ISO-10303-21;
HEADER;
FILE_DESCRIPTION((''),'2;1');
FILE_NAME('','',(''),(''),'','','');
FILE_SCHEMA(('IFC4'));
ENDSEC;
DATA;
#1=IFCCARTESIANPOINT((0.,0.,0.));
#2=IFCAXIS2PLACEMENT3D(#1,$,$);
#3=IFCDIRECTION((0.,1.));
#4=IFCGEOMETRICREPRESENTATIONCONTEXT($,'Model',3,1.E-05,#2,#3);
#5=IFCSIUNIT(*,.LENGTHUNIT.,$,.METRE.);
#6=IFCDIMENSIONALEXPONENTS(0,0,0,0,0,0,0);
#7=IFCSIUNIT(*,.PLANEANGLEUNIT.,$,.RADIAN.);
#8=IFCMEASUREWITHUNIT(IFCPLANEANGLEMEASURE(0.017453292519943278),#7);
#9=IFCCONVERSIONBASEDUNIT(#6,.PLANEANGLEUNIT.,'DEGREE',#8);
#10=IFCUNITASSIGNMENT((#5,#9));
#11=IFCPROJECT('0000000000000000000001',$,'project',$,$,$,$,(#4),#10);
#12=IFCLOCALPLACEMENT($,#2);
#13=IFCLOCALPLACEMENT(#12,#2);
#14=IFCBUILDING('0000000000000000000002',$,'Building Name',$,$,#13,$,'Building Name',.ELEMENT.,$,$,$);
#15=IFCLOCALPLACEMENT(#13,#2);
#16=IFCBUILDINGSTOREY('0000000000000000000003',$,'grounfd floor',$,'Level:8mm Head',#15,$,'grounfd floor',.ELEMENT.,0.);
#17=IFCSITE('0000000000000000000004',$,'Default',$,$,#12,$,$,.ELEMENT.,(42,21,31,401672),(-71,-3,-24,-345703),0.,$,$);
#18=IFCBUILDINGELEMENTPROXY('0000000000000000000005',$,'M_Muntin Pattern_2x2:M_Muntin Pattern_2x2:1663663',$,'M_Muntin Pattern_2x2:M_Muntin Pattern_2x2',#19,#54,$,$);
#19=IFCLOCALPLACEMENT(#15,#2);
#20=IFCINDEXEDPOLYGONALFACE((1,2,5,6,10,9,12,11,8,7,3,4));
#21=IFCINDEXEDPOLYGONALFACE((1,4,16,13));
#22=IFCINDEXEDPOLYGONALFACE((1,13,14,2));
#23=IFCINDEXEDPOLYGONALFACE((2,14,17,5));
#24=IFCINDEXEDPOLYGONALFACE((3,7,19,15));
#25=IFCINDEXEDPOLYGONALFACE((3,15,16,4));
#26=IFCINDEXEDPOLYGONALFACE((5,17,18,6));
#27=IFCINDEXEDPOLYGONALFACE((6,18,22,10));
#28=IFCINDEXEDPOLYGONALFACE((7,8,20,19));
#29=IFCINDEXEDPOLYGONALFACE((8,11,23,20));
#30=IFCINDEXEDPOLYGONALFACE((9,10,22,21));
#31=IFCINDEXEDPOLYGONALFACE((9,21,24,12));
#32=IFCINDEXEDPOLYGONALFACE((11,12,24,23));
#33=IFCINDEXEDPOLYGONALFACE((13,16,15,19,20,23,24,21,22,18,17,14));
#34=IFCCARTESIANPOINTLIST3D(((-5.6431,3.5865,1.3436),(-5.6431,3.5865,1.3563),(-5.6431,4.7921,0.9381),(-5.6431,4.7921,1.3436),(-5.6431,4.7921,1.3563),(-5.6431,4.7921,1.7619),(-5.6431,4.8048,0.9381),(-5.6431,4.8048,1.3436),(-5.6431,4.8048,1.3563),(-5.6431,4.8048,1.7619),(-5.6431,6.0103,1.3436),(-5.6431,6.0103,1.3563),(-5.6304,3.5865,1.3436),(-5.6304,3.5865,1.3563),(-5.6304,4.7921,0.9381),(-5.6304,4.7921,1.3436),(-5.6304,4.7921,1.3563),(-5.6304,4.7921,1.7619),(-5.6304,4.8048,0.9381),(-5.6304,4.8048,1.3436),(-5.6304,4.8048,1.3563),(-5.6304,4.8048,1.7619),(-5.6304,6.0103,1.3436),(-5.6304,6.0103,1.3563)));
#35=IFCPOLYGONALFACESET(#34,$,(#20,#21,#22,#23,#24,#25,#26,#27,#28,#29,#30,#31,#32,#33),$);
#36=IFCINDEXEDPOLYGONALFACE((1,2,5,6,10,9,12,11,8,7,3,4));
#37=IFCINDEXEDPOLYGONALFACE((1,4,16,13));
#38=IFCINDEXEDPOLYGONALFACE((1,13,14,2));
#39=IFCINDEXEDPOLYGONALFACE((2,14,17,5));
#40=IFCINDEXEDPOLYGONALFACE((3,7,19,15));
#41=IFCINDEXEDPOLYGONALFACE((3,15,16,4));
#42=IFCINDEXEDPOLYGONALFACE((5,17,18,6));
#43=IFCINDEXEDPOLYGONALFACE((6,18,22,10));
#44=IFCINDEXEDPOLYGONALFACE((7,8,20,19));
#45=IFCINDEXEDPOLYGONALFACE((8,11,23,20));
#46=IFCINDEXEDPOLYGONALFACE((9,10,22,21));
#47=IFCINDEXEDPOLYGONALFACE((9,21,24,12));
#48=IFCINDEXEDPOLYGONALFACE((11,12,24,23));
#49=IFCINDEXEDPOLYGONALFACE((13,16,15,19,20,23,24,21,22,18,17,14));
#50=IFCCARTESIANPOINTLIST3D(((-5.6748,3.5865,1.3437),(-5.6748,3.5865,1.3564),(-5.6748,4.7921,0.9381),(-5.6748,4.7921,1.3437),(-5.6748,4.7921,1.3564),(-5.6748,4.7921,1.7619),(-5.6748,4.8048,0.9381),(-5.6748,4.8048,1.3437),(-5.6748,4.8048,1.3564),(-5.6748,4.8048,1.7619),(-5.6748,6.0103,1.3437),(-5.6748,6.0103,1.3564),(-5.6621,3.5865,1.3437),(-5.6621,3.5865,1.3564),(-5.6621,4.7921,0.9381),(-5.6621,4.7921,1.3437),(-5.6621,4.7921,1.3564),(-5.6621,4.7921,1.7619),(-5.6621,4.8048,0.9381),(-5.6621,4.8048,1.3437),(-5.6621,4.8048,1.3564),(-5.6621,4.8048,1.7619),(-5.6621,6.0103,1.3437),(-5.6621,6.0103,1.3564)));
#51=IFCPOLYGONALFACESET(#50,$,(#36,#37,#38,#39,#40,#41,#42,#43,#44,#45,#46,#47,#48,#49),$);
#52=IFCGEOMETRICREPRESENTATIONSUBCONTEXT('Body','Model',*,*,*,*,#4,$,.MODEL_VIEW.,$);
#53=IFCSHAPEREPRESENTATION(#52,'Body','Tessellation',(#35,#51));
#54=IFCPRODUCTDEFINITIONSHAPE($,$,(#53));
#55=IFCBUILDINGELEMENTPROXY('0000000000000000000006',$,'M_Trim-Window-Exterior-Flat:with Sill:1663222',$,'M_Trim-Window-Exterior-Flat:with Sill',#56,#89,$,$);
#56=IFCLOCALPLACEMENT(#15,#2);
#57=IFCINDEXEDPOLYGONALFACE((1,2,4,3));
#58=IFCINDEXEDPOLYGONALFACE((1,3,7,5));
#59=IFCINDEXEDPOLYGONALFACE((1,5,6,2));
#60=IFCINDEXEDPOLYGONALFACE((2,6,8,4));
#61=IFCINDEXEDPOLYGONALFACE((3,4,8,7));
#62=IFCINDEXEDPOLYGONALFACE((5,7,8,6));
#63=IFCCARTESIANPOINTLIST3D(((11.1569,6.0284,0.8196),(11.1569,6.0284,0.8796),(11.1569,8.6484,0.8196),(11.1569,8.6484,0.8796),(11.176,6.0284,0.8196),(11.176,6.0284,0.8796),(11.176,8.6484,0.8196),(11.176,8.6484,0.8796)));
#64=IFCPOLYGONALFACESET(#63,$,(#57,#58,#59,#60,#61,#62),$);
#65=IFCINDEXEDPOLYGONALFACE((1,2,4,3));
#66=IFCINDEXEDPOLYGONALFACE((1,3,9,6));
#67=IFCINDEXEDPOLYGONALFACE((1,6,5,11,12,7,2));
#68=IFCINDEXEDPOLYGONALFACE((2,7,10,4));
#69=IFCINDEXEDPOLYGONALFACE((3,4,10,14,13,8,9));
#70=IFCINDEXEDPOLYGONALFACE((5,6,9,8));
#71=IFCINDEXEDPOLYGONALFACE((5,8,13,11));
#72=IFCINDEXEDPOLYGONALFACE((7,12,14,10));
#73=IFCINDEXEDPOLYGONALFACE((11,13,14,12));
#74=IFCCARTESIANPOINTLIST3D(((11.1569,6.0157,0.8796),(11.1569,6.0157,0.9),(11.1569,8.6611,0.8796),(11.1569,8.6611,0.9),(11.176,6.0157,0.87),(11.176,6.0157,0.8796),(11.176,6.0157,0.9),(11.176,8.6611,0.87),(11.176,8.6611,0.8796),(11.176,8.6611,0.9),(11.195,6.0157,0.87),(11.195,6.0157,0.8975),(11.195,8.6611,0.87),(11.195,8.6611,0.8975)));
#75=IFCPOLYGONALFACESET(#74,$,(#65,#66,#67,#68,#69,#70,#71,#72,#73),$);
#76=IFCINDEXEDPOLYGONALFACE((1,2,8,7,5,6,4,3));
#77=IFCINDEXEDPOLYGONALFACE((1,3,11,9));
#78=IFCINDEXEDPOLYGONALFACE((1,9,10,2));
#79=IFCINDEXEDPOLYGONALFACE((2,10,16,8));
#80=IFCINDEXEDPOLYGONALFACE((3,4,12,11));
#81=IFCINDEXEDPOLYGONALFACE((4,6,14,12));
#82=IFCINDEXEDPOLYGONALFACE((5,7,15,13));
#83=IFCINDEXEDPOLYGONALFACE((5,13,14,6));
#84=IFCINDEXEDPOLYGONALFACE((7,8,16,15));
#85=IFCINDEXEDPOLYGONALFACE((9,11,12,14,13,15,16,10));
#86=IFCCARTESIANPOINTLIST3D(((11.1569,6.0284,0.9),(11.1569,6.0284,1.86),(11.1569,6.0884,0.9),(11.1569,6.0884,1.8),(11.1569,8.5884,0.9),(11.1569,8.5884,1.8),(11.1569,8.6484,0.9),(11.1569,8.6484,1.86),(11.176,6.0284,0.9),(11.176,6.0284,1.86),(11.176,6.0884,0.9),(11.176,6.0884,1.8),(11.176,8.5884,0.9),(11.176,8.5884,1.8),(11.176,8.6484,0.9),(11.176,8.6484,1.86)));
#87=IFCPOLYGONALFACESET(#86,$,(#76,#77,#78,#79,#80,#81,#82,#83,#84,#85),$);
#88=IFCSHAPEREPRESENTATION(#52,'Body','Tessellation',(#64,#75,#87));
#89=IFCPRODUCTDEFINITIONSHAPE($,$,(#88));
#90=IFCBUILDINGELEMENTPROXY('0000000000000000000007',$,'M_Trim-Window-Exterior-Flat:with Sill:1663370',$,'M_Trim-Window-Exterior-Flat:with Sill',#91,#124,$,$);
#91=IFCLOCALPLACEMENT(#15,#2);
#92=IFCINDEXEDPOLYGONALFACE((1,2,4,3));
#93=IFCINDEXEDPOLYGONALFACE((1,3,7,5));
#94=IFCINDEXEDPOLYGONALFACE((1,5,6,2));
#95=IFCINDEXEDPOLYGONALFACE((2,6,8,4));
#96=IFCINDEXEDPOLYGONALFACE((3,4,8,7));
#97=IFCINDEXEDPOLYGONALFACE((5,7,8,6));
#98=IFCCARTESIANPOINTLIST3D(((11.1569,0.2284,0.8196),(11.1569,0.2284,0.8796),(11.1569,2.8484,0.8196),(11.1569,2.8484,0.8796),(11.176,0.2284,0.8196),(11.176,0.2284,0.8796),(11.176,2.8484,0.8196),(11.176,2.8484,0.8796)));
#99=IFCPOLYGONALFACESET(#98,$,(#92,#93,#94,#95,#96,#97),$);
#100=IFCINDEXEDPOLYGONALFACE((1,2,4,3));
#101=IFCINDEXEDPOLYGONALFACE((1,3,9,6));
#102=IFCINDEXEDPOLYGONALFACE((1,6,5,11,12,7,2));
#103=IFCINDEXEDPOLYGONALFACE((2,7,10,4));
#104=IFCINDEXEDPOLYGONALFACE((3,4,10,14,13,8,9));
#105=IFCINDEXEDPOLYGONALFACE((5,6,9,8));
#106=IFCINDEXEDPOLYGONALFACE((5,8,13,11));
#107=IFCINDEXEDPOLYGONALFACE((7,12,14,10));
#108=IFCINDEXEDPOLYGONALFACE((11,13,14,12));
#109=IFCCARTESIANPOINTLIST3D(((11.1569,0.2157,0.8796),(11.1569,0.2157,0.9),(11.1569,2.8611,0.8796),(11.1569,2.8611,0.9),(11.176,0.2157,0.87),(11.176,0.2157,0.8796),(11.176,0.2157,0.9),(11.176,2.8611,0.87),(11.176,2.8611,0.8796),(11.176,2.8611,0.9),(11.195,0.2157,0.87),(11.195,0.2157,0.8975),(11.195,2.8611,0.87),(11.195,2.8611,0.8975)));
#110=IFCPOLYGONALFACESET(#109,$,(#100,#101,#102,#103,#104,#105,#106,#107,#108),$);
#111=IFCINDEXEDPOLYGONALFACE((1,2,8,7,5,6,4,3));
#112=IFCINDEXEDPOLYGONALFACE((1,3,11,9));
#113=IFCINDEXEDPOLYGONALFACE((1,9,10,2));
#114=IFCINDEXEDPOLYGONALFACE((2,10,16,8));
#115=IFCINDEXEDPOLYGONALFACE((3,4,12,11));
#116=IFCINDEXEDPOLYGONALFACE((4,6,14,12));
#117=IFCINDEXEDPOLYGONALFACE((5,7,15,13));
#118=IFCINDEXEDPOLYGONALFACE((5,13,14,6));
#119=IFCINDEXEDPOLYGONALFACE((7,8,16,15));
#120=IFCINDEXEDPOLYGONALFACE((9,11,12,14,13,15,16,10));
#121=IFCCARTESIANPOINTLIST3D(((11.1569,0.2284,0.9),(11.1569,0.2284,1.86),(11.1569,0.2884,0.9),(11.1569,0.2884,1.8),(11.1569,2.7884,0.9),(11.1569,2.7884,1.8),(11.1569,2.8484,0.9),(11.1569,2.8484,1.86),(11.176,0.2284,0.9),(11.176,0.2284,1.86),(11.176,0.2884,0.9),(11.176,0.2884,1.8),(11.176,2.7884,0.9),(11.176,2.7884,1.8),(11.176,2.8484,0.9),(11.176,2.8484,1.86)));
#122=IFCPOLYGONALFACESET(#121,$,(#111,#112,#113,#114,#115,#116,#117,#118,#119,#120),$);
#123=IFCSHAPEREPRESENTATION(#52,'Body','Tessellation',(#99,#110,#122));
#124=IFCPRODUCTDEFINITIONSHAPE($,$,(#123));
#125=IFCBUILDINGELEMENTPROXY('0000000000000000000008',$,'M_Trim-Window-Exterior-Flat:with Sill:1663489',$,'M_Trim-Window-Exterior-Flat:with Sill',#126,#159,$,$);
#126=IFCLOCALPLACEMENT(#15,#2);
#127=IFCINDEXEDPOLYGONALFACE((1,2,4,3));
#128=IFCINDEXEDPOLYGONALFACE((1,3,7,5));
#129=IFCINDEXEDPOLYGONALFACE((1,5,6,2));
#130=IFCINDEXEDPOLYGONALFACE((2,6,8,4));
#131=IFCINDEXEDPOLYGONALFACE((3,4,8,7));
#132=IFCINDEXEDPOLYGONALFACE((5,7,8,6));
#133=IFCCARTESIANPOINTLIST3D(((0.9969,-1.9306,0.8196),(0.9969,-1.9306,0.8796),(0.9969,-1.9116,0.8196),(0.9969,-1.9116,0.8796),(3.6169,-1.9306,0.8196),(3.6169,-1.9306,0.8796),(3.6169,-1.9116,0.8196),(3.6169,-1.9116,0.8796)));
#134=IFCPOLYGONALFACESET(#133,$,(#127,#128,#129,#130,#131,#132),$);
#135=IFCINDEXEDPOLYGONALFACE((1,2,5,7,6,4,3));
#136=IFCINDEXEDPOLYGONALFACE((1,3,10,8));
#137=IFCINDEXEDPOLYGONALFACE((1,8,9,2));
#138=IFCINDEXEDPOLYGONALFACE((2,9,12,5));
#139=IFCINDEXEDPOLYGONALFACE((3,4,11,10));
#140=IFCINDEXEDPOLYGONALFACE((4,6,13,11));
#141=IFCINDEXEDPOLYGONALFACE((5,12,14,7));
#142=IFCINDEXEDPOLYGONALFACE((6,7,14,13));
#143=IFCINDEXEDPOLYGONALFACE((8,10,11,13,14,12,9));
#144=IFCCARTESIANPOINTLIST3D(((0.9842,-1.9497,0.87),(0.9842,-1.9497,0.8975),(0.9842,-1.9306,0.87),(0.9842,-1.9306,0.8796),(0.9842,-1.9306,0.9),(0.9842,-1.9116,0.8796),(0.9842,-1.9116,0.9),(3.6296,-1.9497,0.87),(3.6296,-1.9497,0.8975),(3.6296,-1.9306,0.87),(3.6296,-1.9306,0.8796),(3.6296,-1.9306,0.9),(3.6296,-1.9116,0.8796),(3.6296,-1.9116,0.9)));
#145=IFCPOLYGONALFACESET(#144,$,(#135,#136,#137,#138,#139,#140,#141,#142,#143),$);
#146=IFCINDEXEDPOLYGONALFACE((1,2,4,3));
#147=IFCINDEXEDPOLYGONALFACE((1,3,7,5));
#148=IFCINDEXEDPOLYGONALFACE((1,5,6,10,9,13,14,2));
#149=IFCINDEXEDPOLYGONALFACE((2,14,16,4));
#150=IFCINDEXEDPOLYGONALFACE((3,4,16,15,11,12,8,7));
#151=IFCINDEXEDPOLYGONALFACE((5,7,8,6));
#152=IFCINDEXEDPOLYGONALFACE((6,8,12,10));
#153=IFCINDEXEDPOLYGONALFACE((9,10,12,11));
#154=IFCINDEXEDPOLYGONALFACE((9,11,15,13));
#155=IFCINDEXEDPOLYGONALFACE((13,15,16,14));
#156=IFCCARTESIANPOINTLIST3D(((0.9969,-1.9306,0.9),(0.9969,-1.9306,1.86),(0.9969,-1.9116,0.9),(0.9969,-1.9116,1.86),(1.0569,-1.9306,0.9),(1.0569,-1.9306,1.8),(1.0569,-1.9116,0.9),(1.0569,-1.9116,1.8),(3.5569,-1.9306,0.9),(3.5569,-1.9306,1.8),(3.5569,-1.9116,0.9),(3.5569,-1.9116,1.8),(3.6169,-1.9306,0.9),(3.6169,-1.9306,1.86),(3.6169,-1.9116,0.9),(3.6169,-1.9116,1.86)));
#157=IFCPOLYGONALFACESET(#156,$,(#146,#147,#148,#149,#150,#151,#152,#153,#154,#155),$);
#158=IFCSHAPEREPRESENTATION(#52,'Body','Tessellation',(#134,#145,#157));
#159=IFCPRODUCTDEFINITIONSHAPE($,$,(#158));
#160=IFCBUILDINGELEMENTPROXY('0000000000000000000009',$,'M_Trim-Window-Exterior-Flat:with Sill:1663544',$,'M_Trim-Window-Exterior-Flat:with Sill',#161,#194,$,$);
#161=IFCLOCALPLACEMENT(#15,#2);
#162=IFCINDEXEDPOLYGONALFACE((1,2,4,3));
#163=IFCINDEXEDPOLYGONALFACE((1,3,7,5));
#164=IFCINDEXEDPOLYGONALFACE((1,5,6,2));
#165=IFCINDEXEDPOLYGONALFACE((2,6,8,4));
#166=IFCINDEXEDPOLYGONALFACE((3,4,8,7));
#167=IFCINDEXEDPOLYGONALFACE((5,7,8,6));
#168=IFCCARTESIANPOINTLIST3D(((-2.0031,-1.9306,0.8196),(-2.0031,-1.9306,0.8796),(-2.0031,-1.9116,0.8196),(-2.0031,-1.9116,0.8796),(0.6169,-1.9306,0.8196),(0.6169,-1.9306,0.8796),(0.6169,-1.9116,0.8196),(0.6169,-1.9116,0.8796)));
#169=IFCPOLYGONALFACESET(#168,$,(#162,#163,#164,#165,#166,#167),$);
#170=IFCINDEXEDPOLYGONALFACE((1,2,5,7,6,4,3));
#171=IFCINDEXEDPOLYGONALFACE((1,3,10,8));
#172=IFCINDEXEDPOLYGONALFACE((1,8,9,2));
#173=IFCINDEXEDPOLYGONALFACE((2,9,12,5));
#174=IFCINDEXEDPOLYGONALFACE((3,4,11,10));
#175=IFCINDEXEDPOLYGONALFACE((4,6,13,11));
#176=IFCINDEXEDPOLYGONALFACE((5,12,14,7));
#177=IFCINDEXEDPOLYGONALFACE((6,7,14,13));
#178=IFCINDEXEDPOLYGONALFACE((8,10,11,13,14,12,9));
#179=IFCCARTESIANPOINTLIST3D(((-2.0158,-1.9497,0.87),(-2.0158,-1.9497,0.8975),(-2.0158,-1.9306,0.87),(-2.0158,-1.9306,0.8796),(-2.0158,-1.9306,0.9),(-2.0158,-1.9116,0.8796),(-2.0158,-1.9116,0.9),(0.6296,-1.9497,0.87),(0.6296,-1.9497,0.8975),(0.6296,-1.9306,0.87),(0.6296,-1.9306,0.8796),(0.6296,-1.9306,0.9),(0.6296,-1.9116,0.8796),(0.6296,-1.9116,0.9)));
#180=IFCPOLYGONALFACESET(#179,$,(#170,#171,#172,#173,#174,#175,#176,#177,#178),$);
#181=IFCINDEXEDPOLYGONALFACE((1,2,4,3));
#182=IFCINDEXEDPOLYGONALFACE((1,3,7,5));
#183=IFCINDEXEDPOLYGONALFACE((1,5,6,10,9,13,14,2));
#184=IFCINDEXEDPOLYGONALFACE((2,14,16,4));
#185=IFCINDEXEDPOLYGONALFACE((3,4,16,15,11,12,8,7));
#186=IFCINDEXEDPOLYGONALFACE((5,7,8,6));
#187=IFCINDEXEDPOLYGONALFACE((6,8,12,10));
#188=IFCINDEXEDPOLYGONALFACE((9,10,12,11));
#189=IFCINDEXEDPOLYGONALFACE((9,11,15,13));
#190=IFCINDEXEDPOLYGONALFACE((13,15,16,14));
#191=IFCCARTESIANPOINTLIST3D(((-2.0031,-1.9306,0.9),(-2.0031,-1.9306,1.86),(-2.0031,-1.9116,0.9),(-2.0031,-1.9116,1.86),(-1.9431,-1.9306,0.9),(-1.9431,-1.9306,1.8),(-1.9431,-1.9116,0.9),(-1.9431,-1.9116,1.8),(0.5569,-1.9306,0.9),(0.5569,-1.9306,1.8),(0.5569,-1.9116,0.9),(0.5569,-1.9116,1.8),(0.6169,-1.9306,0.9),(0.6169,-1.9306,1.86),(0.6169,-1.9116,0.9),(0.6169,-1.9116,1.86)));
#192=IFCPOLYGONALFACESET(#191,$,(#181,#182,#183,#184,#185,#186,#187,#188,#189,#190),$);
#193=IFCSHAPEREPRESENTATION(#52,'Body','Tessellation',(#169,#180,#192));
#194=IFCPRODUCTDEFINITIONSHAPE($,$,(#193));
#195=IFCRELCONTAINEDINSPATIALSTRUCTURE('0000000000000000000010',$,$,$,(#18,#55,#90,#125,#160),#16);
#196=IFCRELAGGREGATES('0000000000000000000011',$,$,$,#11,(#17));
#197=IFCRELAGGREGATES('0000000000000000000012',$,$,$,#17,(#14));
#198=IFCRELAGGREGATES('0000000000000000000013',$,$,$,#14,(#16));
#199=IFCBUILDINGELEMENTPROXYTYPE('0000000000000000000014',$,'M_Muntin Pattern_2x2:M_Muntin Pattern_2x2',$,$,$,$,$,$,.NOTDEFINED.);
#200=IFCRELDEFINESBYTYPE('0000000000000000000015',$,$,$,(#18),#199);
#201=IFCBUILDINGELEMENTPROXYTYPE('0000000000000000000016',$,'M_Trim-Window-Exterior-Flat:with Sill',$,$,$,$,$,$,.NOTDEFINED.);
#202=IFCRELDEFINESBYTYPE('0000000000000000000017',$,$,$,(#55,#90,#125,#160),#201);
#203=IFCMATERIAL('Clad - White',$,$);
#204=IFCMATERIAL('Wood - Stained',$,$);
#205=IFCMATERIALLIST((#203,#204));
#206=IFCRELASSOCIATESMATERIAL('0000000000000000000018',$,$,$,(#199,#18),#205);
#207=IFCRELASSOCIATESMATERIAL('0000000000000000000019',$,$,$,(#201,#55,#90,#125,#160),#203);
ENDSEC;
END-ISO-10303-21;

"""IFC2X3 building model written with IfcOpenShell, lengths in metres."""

from ifc_helpers import new_model, entity, si_unit, converted_unit, direction, frame, frame_2d, origin, place, context, subcontext, project, spatial, polyline, rectangle, outline, extrude, source, transform, mapped, material, material_list, type_object, type_shapes, element, save


model = new_model("IFC2X3")

# Units and contexts
model_context = context("Model", 3, precision=1e-05, world=origin(), true_north=direction((0.0, 1.0)))
body_context = subcontext(model_context, "Body", "Model", "MODEL_VIEW")
ifc_project = project(units=[si_unit("LENGTHUNIT", "METRE"), converted_unit("PLANEANGLEUNIT", "DEGREE", entity("IfcPlaneAngleMeasure", 0.017453292519943278), si_unit("PLANEANGLEUNIT", "RADIAN"), dimensions=[0, 0, 0, 0, 0, 0, 0])], contexts=[model_context])

# Site, building, storey
site_placement = place(None, origin())
site = spatial("IfcSite", under=ifc_project, at=site_placement, Name="Default", CompositionType="ELEMENT", RefLatitude=(42, 21, 31, 401672), RefLongitude=(-71, -3, -24, -345703), RefElevation=0.0)
building_placement = place(site_placement, origin())
building = spatial("IfcBuilding", under=site, at=building_placement, Name="Building Name", LongName="Building Name", CompositionType="ELEMENT")
storey_placement = place(building_placement, origin())
storey = spatial("IfcBuildingStorey", under=building, at=storey_placement, Name="grounfd floor", ObjectType="Level:8mm Head", LongName="grounfd floor", CompositionType="ELEMENT", Elevation=0.0)

# Building element proxies
ifc_material_1 = material(Name="Clad - White")
ifc_material_2 = material(Name="Wood - Stained")
ifc_material_list = material_list([ifc_material_1, ifc_material_2])
building_element_proxy_type_1 = type_object("IfcBuildingElementProxyType", Name="M_Muntin Pattern_2x2:M_Muntin Pattern_2x2", PredefinedType="NOTDEFINED", material=ifc_material_list)
shared_shape_1 = source(origin(), body_context, "Body", "SweptSolid", [
    extrude(outline(polyline([(0.0064, -0.0064), (0.4119, -0.0064), (0.4119, 0.0063), (0.0064, 0.0063), (0.0064, 1.2119), (-0.0063, 1.2119), (-0.0063, 0.0063), (-0.4119, 0.0063), (-0.4119, -0.0064), (-0.0063, -0.0064), (-0.0063, -1.2119), (0.0064, -1.2119), (0.0064, -0.0064)])), frame((0.0, -0.0222, 0.4119), z_axis=(0.0, 1.0, 0.0), x_axis=(0.0, 0.0, 1.0)), (0.0, 0.0, 1.0), 0.0127),
    extrude(outline(polyline([(0.0064, -0.0064), (0.4119, -0.0064), (0.4119, 0.0063), (0.0064, 0.0063), (0.0064, 1.2119), (-0.0063, 1.2119), (-0.0063, 0.0063), (-0.4119, 0.0063), (-0.4119, -0.0064), (-0.0063, -0.0064), (-0.0063, -1.2119), (0.0064, -1.2119), (0.0064, -0.0064)])), frame((0.0, 0.0095, 0.4119), z_axis=(0.0, 1.0, 0.0), x_axis=(0.0, 0.0, 1.0)), (0.0, 0.0, 1.0), 0.0127),
])
type_shapes(building_element_proxy_type_1, [shared_shape_1])
proxy_1_placement = place(storey_placement, frame((-5.6526, 4.7984, 0.9381), z_axis=(0.0, 0.0, 1.0), x_axis=(0.0, 1.0, 0.0)))
element("IfcBuildingElementProxy", 1, at=proxy_1_placement, inside=storey, type_object=building_element_proxy_type_1, material=ifc_material_list, Name="M_Muntin Pattern_2x2:M_Muntin Pattern_2x2:1663663", ObjectType="M_Muntin Pattern_2x2:M_Muntin Pattern_2x2", context=body_context, shape_type="MappedRepresentation", body=[
    mapped(shared_shape_1, transform((0.0, 0.0, 0.0), scale=1.0)),
])
building_element_proxy_type_2 = type_object("IfcBuildingElementProxyType", Name="M_Trim-Window-Exterior-Flat:with Sill", PredefinedType="NOTDEFINED", material=ifc_material_1)
shared_shape_2 = source(origin(), body_context, "Body", "SweptSolid", [
    extrude(rectangle(XDim=2.62, YDim=0.06, at=frame_2d((0.0, 0.0), x_axis=(1.0, 0.0))), frame((0.0, -0.9504, 0.0), z_axis=(0.0, 0.0, 1.0), x_axis=(-1.0, 0.0, 0.0)), (0.0, 0.0, 1.0), 0.019),
    extrude(outline(polyline([(-0.019, -0.0152), (0.0, -0.0152), (0.0, -0.0057), (0.019, -0.0057), (0.019, 0.0148), (0.0, 0.0148), (-0.019, 0.0123), (-0.019, -0.0152)])), frame((-1.3227, -0.9148, 0.019), z_axis=(1.0, 0.0, 0.0), x_axis=(0.0, 0.0, -1.0)), (0.0, 0.0, 1.0), 2.6454),
    extrude(outline(polyline([(-0.495, -1.31), (0.465, -1.31), (0.465, -1.25), (-0.435, -1.25), (-0.435, 1.25), (0.465, 1.25), (0.465, 1.31), (-0.495, 1.31), (-0.495, -1.31)])), frame((0.0, -0.435, 0.0), z_axis=(0.0, 0.0, 1.0), x_axis=(0.0, -1.0, 0.0)), (0.0, 0.0, 1.0), 0.019),
])
type_shapes(building_element_proxy_type_2, [shared_shape_2])
for number, where, z_axis, x_axis, name in (
    (2, (11.1569, 7.3384, 1.8), (1.0, 0.0, 0.0), (0.0, 1.0, 0.0), "M_Trim-Window-Exterior-Flat:with Sill:1663222"),
    (3, (11.1569, 1.5384, 1.8), (1.0, 0.0, 0.0), (0.0, 1.0, 0.0), "M_Trim-Window-Exterior-Flat:with Sill:1663370"),
    (4, (2.3069, -1.9116, 1.8), (0.0, -1.0, 0.0), (1.0, 0.0, 0.0), "M_Trim-Window-Exterior-Flat:with Sill:1663489"),
    (5, (-0.6931, -1.9116, 1.8), (0.0, -1.0, 0.0), (1.0, 0.0, 0.0), "M_Trim-Window-Exterior-Flat:with Sill:1663544"),
):
    element("IfcBuildingElementProxy", number, at=place(storey_placement, frame(where, z_axis=z_axis, x_axis=x_axis)), inside=storey, type_object=building_element_proxy_type_2, material=ifc_material_1, Name=name, ObjectType="M_Trim-Window-Exterior-Flat:with Sill", context=body_context, shape_type="MappedRepresentation", body=[
        mapped(shared_shape_2, transform((0.0, 0.0, 0.0), scale=1.0)),
    ])

save(model, "model.ifc")
